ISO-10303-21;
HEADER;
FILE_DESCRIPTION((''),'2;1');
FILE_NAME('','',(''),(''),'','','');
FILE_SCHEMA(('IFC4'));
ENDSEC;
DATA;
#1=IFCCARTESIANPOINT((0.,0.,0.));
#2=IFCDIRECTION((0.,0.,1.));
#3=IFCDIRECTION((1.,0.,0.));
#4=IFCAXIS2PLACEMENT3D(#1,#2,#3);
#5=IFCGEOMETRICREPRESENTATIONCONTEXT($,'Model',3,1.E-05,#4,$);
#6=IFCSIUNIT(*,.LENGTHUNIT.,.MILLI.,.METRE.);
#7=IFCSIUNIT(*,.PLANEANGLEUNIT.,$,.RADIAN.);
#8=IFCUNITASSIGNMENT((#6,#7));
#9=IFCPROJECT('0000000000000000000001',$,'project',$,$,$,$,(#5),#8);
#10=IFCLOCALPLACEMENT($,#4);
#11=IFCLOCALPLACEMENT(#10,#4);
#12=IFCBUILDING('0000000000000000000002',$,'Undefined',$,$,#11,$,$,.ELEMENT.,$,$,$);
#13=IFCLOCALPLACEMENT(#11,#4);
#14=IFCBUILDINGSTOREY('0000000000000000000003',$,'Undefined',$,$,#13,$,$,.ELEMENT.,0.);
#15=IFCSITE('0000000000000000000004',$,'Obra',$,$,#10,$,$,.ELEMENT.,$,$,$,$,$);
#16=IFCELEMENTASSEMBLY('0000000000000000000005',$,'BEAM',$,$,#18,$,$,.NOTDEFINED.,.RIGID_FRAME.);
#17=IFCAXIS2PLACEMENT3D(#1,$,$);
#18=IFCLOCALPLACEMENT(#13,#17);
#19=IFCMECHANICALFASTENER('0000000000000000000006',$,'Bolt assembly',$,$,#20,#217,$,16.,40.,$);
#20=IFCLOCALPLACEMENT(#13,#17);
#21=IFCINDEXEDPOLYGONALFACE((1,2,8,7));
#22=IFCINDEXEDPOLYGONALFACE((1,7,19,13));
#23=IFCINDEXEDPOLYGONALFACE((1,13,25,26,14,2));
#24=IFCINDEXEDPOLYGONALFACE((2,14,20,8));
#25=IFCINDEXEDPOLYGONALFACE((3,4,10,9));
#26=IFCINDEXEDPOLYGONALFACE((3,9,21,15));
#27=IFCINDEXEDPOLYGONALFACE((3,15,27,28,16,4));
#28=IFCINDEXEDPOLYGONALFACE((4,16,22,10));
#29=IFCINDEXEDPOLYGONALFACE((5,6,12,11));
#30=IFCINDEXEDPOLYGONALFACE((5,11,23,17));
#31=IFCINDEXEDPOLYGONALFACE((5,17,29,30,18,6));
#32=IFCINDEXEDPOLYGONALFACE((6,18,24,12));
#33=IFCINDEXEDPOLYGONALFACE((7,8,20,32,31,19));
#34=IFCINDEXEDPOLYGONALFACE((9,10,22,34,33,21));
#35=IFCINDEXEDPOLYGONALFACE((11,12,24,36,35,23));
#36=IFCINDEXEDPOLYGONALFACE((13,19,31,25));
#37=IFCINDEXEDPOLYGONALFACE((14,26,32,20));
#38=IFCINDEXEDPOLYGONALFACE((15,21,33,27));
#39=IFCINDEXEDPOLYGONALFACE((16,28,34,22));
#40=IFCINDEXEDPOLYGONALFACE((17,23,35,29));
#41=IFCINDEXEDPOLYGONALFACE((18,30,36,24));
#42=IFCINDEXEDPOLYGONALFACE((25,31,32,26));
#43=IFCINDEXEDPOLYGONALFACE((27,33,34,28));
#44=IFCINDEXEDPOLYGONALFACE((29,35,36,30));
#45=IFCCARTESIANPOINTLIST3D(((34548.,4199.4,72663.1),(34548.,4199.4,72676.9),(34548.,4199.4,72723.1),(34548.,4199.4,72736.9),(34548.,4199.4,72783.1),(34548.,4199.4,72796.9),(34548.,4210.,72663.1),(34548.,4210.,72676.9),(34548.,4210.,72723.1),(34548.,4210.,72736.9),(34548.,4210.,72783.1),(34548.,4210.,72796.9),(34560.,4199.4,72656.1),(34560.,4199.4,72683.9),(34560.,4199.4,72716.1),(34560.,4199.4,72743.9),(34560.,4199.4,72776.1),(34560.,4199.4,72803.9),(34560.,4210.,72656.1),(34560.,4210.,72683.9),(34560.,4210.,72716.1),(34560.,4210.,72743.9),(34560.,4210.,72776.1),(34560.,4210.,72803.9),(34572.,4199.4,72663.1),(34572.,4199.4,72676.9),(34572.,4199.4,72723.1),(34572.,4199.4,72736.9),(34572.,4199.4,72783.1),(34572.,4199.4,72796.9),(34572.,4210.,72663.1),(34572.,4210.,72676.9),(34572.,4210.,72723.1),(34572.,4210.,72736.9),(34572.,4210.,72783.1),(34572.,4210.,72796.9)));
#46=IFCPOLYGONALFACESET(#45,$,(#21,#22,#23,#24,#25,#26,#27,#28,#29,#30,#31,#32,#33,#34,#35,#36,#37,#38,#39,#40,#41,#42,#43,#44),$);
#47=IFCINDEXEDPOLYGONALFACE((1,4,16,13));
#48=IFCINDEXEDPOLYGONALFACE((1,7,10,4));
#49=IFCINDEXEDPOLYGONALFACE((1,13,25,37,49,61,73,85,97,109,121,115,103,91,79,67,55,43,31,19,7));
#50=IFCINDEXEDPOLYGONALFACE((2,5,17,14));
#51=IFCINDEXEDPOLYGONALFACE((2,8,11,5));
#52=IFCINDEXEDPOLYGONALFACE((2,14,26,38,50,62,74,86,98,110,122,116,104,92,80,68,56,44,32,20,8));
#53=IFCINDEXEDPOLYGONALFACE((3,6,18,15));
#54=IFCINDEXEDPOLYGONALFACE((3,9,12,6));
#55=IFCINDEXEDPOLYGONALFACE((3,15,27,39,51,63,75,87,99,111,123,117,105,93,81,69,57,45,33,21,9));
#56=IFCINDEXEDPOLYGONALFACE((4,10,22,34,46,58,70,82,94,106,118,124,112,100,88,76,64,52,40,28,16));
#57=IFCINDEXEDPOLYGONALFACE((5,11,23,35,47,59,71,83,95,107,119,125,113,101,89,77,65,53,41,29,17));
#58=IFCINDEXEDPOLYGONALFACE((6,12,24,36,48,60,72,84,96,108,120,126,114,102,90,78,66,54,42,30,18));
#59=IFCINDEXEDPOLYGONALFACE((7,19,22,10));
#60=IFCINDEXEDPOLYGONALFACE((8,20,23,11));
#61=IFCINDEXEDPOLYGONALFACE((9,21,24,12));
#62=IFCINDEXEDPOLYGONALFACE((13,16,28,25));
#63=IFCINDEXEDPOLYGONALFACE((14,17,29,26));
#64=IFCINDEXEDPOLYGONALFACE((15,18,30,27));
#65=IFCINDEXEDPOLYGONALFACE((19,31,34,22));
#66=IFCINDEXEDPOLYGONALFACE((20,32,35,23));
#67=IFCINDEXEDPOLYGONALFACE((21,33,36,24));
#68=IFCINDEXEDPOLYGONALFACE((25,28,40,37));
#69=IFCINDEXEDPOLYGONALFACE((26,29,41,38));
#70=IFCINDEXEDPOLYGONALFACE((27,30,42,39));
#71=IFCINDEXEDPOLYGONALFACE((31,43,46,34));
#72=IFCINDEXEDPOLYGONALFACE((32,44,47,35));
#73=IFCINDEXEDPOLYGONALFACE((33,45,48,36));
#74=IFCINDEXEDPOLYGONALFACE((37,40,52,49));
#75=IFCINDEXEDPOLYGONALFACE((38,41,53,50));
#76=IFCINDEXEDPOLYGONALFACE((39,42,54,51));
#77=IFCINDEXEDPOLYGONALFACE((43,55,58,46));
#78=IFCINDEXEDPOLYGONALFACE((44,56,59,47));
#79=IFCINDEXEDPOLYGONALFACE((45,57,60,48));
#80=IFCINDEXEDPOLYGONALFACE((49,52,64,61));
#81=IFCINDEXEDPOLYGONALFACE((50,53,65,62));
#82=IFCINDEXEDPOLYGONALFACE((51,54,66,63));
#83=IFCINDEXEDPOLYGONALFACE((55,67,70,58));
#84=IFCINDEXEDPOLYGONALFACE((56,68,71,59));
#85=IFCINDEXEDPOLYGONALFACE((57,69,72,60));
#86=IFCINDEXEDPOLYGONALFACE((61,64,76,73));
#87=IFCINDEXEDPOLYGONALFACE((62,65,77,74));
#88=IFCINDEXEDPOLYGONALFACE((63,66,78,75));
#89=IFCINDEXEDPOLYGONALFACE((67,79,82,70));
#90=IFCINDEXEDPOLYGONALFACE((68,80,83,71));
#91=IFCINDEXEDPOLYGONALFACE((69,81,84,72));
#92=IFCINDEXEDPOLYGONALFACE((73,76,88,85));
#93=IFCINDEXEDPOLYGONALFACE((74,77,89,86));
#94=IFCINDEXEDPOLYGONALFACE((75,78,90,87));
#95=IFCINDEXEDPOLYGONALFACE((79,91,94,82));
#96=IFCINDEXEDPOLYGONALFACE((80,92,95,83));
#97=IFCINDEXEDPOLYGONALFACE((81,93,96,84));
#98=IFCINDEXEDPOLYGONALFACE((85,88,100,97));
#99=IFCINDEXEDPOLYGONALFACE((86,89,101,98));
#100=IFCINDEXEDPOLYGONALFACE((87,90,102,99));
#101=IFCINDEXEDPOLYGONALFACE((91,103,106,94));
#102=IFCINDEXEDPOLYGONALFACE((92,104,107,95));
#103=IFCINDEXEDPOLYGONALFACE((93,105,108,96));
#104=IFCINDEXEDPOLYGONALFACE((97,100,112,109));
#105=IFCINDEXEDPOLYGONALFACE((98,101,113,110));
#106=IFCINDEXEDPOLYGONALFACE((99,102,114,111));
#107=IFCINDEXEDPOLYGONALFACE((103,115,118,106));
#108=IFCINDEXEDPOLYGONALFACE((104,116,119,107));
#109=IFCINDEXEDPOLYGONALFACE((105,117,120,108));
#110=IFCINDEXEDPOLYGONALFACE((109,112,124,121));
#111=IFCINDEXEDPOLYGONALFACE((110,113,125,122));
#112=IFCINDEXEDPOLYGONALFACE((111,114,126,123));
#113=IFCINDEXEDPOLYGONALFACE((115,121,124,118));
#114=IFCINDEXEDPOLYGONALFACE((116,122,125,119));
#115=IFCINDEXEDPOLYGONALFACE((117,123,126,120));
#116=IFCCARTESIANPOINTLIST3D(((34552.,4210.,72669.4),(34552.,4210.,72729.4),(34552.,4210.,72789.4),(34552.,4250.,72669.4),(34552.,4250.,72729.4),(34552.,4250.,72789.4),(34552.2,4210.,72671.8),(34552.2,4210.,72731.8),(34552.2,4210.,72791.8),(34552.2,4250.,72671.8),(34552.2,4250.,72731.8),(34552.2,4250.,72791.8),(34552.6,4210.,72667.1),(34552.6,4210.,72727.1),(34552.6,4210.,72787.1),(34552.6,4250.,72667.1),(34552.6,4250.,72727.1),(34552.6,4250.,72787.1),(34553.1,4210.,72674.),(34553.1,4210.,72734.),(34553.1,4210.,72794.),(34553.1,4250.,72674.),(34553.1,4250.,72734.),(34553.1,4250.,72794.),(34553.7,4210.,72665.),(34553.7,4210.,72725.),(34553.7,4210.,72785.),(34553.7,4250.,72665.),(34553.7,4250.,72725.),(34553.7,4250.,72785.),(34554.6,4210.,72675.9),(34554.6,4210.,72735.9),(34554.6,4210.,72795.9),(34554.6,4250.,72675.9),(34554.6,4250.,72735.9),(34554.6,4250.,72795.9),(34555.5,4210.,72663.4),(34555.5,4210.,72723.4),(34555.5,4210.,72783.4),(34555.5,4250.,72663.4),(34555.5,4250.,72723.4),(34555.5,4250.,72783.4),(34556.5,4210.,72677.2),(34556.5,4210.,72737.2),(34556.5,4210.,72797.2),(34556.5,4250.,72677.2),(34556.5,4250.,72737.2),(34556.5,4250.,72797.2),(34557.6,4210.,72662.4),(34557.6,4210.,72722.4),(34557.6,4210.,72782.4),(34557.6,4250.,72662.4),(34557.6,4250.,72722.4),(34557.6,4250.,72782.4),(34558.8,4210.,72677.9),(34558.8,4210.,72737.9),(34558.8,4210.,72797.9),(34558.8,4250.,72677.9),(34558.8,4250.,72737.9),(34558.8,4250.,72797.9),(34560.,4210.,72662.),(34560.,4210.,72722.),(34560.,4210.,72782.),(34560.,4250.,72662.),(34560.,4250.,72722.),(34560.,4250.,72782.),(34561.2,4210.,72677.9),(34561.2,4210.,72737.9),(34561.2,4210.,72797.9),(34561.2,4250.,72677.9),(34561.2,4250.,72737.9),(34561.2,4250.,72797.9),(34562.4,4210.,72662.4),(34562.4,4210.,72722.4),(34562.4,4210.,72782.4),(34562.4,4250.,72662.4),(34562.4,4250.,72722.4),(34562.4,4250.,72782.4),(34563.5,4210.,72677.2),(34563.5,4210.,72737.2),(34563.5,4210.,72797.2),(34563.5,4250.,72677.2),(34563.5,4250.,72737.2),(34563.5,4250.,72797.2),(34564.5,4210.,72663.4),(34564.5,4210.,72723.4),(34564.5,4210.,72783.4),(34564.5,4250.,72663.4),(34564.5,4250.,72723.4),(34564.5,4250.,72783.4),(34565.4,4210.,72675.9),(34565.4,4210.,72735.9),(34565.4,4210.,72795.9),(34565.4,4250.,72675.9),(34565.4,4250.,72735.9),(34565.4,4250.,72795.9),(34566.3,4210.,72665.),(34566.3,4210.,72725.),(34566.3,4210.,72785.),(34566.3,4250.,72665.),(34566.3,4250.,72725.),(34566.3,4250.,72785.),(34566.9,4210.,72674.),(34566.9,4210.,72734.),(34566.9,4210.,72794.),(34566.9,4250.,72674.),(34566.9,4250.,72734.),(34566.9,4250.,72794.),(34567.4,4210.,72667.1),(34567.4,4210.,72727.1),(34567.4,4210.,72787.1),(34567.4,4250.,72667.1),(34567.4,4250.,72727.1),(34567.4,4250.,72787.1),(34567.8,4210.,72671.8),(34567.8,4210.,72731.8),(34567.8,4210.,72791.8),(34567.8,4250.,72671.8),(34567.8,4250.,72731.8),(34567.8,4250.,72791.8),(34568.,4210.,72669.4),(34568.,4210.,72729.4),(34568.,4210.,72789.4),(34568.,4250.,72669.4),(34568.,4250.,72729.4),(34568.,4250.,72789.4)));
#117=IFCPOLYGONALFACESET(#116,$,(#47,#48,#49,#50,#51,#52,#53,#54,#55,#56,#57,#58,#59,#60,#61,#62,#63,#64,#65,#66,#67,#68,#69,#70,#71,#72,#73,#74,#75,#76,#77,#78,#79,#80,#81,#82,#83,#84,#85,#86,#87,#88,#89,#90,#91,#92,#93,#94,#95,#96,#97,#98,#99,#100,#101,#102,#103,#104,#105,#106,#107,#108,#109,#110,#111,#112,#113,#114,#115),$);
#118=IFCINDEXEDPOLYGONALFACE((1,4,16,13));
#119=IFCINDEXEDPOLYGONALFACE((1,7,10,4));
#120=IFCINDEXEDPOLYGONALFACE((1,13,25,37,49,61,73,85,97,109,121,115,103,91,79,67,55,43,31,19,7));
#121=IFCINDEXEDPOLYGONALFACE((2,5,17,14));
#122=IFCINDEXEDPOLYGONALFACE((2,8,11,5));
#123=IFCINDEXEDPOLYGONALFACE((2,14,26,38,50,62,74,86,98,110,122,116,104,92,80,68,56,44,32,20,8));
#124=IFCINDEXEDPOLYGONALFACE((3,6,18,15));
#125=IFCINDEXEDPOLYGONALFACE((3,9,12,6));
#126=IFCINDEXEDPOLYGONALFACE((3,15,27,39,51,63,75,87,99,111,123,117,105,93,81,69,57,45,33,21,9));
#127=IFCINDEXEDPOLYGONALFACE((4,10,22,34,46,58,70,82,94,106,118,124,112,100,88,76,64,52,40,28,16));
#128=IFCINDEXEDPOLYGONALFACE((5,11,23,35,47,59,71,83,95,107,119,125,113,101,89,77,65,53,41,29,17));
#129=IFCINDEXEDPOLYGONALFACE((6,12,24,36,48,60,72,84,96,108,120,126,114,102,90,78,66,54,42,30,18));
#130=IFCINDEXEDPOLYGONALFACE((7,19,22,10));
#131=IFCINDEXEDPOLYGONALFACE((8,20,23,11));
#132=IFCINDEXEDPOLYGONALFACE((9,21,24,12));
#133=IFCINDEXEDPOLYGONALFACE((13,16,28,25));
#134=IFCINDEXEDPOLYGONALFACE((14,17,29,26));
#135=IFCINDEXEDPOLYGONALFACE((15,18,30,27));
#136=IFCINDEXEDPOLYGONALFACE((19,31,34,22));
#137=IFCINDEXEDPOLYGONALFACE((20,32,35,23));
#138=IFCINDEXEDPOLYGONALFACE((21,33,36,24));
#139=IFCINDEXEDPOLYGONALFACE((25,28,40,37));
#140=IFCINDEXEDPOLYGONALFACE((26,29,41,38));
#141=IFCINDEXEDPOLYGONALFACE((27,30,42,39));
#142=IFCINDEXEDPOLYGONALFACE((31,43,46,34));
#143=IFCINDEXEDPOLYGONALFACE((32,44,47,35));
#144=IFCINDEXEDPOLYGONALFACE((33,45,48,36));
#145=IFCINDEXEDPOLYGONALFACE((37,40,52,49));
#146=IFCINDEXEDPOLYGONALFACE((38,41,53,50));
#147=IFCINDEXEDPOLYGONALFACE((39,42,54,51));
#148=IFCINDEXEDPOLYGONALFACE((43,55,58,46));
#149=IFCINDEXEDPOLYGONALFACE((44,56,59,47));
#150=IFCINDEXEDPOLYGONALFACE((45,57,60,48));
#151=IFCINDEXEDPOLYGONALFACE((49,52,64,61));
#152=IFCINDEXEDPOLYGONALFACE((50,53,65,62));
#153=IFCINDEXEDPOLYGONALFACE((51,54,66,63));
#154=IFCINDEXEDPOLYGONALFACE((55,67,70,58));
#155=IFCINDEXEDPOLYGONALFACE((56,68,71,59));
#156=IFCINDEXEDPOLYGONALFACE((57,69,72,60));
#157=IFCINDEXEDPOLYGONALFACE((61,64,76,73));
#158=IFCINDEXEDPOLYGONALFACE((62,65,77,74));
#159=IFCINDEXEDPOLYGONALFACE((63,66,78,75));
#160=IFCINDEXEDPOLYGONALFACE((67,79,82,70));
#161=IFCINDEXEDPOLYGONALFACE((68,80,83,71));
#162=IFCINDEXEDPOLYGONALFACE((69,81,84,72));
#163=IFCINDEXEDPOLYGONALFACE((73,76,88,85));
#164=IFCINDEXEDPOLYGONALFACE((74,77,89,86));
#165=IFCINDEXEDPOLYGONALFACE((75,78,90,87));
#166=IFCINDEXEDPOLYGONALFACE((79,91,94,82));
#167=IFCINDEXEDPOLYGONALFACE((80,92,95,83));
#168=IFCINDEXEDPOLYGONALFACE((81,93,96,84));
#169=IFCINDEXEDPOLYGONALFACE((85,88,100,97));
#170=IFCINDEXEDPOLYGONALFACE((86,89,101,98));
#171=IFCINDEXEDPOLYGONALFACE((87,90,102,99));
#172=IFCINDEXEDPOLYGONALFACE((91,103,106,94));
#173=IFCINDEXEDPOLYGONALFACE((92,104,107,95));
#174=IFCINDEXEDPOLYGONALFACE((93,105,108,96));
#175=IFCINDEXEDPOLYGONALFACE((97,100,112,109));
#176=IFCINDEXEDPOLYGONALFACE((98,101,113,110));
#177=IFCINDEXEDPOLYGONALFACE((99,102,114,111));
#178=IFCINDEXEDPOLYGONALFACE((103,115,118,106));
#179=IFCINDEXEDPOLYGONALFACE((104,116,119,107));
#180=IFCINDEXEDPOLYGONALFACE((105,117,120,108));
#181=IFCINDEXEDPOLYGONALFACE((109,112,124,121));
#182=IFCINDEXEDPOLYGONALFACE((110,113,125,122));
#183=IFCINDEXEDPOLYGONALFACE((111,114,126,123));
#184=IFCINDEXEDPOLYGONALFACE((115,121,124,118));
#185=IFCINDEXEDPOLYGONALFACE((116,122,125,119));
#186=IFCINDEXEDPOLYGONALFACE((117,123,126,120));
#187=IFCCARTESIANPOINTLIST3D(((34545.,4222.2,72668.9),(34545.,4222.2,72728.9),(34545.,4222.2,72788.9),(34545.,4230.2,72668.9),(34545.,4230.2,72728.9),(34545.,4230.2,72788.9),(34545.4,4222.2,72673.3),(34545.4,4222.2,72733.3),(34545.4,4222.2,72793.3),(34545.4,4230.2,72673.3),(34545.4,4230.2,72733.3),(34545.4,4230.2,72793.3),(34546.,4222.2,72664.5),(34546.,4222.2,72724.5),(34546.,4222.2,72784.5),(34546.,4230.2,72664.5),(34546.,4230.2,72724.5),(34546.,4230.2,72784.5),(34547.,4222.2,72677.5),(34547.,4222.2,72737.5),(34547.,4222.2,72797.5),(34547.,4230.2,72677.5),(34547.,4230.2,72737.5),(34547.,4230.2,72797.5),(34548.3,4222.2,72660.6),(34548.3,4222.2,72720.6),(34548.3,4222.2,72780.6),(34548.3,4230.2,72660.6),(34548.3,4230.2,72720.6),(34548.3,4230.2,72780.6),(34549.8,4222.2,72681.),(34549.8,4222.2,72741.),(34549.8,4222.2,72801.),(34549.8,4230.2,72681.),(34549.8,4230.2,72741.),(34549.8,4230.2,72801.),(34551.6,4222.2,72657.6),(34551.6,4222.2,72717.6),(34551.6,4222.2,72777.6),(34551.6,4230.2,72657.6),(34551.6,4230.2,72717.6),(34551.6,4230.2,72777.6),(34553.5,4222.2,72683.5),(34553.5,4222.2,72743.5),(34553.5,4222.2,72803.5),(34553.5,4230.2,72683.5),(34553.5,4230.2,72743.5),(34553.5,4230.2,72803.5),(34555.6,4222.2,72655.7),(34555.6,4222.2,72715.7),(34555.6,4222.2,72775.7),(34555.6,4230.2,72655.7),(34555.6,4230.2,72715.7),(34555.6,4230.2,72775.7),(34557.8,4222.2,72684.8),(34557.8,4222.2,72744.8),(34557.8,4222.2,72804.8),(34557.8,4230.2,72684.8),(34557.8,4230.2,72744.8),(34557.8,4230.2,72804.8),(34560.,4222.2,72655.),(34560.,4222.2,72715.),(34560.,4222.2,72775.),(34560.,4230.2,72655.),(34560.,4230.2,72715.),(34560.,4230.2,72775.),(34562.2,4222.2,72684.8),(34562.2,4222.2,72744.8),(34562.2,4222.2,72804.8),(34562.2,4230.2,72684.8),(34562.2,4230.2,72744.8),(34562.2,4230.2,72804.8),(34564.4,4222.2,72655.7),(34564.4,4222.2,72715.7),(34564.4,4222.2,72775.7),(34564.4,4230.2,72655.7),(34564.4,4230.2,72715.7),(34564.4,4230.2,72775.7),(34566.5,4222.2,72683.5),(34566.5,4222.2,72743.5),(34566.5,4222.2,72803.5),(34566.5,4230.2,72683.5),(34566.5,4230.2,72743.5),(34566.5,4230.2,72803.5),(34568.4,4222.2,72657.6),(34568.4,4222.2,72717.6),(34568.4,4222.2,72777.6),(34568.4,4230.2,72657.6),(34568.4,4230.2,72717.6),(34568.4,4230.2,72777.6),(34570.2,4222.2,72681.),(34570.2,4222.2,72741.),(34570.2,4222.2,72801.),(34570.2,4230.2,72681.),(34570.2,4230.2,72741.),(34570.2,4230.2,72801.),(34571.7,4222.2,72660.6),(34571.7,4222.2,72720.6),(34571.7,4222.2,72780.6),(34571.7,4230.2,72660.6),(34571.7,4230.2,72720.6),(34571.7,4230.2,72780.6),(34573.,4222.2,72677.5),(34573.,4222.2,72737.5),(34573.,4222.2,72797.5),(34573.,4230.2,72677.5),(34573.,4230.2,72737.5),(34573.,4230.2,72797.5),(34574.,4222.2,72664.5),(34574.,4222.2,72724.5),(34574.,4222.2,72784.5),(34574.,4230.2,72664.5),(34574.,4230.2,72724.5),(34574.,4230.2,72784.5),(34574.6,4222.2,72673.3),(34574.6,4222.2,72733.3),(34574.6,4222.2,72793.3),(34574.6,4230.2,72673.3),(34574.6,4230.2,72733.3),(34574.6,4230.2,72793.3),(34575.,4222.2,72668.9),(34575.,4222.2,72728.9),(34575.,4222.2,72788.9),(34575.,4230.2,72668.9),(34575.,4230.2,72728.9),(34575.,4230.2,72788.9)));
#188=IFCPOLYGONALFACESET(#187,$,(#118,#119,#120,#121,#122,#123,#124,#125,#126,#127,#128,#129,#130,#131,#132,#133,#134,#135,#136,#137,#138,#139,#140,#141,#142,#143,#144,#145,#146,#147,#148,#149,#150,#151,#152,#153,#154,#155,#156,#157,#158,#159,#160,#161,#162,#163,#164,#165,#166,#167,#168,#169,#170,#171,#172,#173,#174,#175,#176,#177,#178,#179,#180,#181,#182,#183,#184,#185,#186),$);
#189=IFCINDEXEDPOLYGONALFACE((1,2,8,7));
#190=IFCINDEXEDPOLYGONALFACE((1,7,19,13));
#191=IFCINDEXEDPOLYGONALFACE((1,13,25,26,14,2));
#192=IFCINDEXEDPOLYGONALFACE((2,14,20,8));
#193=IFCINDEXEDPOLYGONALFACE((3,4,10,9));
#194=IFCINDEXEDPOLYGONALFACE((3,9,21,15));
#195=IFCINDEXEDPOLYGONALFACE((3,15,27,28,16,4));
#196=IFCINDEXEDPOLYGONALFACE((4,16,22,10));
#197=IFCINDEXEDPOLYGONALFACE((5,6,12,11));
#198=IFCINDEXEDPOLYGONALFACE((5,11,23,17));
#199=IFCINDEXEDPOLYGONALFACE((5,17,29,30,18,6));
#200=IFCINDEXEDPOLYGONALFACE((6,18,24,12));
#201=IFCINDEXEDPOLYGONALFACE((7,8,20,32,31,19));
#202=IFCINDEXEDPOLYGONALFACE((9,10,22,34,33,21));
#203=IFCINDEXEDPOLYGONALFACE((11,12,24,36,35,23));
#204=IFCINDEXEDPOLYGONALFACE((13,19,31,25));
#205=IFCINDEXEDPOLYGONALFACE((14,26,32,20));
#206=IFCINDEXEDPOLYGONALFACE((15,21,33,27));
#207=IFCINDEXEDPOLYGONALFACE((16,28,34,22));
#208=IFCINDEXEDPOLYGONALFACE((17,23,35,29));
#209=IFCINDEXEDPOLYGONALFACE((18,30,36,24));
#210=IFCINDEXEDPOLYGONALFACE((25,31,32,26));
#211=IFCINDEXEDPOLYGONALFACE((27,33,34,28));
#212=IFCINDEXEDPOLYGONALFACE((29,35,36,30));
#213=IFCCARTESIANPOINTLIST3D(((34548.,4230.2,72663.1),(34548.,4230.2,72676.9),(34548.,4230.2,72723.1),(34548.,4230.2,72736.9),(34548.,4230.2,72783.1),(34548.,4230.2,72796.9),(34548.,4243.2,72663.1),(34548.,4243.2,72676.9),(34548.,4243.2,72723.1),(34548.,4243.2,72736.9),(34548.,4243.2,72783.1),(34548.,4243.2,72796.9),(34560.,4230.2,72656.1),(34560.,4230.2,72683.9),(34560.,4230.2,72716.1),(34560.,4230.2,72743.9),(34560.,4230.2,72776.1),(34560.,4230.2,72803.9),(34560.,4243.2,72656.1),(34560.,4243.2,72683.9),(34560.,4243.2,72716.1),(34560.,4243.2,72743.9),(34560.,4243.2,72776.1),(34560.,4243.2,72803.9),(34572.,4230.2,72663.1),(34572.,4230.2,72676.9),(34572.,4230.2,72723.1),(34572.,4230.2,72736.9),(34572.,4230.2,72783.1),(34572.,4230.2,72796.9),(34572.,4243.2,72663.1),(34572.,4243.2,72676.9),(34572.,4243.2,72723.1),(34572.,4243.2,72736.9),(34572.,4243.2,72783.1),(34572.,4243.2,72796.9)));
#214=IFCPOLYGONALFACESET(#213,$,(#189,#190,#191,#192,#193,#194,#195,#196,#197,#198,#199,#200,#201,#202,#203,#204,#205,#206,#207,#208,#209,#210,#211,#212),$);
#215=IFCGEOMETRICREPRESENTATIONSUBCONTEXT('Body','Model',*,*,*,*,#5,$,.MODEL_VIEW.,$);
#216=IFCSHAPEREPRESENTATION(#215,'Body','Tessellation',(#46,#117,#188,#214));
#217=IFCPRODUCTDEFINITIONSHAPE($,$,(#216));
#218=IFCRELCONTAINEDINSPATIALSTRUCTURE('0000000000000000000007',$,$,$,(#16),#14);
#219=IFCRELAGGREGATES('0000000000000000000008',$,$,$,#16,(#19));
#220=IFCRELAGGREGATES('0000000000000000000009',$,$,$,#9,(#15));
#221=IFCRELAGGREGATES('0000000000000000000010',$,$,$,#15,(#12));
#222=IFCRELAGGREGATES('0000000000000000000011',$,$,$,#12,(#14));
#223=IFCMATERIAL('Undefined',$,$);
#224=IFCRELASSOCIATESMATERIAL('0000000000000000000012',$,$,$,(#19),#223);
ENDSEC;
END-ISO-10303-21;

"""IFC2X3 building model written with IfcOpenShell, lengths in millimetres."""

from ifc_helpers import new_model, si_unit, frame, origin_with_axes, origin_2d_with_axis, place, context, subcontext, project, spatial, polyline, circle, outline, extrude, source, transform, mapped, material, element, aggregate, save


model = new_model("IFC2X3")

# Units and contexts
model_context = context("Model", 3, precision=1e-05, world=origin_with_axes())
body_context = subcontext(model_context, "Body", "Model", "MODEL_VIEW")
ifc_project = project(units=[si_unit("LENGTHUNIT", "METRE", prefix="MILLI"), si_unit("PLANEANGLEUNIT", "RADIAN")], contexts=[model_context])

# Site, building, storey
site_placement = place(None, origin_with_axes())
site = spatial("IfcSite", under=ifc_project, at=site_placement, Name="Obra", CompositionType="ELEMENT")
building_placement = place(site_placement, origin_with_axes())
building = spatial("IfcBuilding", under=site, at=building_placement, Name="Undefined", CompositionType="ELEMENT")
storey_placement = place(building_placement, origin_with_axes())
storey = spatial("IfcBuildingStorey", under=building, at=storey_placement, Name="Undefined", CompositionType="ELEMENT", Elevation=0.0)

# Shared definitions
ifc_material = material(Name="Undefined")

# Element assembly, mechanical fastener
shared_shape_1 = source(origin_with_axes(), body_context, "Body", "SweptSolid", [
    extrude(outline(polyline([(13.9, 0.0), (6.9, 12.0), (-6.9, 12.0), (-13.9, 0.0), (-6.9, -12.0), (6.9, -12.0), (13.9, 0.0)])), frame((0.0, -19.7, 0.0), z_axis=(0.0, 1.0, 0.0), x_axis=(1.0, 0.0, 0.0)), (0.0, 0.0, 1.0), 10.6),
    extrude(circle(Radius=8.0, at=origin_2d_with_axis()), frame((0.0, -9.1, 0.0), z_axis=(0.0, 1.0, 0.0), x_axis=(1.0, 0.0, 0.0)), (0.0, 0.0, 1.0), 40.0),
    extrude(circle(Radius=15.0, at=origin_2d_with_axis()), frame((0.0, 3.1, 0.0), z_axis=(0.0, 1.0, 0.0), x_axis=(1.0, 0.0, 0.0)), (0.0, 0.0, 1.0), 8.0),
    extrude(outline(polyline([(13.9, 0.0), (6.9, 12.0), (-6.9, 12.0), (-13.9, 0.0), (-6.9, -12.0), (6.9, -12.0), (13.9, 0.0)])), frame((0.0, 11.1, 0.0), z_axis=(0.0, 1.0, 0.0), x_axis=(1.0, 0.0, 0.0)), (0.0, 0.0, 1.0), 13.0),
])
assembly_1_placement = place(storey_placement, origin_with_axes())
assembly_1 = element("IfcElementAssembly", 1, at=assembly_1_placement, inside=storey, Name="BEAM", AssemblyPlace="NOTDEFINED", PredefinedType="RIGID_FRAME")
mechanical_fastener_1_placement = place(assembly_1_placement, frame((34510.0, 4219.1, 72850.0), z_axis=(1.0, 0.0, 0.0), x_axis=(0.0, 0.0, -1.0)))
mechanical_fastener_1 = element("IfcMechanicalFastener", 2, at=mechanical_fastener_1_placement, material=ifc_material, Name="Bolt assembly", NominalDiameter=16.0, NominalLength=40.0, context=body_context, shape_type="MappedRepresentation", body=[
    mapped(shared_shape_1, transform((60.0, 0.0, 50.0))),
    mapped(shared_shape_1, transform((120.0, 0.0, 50.0))),
    mapped(shared_shape_1, transform((180.0, 0.0, 50.0))),
])
aggregate(assembly_1, [mechanical_fastener_1])

save(model, "model.ifc")
